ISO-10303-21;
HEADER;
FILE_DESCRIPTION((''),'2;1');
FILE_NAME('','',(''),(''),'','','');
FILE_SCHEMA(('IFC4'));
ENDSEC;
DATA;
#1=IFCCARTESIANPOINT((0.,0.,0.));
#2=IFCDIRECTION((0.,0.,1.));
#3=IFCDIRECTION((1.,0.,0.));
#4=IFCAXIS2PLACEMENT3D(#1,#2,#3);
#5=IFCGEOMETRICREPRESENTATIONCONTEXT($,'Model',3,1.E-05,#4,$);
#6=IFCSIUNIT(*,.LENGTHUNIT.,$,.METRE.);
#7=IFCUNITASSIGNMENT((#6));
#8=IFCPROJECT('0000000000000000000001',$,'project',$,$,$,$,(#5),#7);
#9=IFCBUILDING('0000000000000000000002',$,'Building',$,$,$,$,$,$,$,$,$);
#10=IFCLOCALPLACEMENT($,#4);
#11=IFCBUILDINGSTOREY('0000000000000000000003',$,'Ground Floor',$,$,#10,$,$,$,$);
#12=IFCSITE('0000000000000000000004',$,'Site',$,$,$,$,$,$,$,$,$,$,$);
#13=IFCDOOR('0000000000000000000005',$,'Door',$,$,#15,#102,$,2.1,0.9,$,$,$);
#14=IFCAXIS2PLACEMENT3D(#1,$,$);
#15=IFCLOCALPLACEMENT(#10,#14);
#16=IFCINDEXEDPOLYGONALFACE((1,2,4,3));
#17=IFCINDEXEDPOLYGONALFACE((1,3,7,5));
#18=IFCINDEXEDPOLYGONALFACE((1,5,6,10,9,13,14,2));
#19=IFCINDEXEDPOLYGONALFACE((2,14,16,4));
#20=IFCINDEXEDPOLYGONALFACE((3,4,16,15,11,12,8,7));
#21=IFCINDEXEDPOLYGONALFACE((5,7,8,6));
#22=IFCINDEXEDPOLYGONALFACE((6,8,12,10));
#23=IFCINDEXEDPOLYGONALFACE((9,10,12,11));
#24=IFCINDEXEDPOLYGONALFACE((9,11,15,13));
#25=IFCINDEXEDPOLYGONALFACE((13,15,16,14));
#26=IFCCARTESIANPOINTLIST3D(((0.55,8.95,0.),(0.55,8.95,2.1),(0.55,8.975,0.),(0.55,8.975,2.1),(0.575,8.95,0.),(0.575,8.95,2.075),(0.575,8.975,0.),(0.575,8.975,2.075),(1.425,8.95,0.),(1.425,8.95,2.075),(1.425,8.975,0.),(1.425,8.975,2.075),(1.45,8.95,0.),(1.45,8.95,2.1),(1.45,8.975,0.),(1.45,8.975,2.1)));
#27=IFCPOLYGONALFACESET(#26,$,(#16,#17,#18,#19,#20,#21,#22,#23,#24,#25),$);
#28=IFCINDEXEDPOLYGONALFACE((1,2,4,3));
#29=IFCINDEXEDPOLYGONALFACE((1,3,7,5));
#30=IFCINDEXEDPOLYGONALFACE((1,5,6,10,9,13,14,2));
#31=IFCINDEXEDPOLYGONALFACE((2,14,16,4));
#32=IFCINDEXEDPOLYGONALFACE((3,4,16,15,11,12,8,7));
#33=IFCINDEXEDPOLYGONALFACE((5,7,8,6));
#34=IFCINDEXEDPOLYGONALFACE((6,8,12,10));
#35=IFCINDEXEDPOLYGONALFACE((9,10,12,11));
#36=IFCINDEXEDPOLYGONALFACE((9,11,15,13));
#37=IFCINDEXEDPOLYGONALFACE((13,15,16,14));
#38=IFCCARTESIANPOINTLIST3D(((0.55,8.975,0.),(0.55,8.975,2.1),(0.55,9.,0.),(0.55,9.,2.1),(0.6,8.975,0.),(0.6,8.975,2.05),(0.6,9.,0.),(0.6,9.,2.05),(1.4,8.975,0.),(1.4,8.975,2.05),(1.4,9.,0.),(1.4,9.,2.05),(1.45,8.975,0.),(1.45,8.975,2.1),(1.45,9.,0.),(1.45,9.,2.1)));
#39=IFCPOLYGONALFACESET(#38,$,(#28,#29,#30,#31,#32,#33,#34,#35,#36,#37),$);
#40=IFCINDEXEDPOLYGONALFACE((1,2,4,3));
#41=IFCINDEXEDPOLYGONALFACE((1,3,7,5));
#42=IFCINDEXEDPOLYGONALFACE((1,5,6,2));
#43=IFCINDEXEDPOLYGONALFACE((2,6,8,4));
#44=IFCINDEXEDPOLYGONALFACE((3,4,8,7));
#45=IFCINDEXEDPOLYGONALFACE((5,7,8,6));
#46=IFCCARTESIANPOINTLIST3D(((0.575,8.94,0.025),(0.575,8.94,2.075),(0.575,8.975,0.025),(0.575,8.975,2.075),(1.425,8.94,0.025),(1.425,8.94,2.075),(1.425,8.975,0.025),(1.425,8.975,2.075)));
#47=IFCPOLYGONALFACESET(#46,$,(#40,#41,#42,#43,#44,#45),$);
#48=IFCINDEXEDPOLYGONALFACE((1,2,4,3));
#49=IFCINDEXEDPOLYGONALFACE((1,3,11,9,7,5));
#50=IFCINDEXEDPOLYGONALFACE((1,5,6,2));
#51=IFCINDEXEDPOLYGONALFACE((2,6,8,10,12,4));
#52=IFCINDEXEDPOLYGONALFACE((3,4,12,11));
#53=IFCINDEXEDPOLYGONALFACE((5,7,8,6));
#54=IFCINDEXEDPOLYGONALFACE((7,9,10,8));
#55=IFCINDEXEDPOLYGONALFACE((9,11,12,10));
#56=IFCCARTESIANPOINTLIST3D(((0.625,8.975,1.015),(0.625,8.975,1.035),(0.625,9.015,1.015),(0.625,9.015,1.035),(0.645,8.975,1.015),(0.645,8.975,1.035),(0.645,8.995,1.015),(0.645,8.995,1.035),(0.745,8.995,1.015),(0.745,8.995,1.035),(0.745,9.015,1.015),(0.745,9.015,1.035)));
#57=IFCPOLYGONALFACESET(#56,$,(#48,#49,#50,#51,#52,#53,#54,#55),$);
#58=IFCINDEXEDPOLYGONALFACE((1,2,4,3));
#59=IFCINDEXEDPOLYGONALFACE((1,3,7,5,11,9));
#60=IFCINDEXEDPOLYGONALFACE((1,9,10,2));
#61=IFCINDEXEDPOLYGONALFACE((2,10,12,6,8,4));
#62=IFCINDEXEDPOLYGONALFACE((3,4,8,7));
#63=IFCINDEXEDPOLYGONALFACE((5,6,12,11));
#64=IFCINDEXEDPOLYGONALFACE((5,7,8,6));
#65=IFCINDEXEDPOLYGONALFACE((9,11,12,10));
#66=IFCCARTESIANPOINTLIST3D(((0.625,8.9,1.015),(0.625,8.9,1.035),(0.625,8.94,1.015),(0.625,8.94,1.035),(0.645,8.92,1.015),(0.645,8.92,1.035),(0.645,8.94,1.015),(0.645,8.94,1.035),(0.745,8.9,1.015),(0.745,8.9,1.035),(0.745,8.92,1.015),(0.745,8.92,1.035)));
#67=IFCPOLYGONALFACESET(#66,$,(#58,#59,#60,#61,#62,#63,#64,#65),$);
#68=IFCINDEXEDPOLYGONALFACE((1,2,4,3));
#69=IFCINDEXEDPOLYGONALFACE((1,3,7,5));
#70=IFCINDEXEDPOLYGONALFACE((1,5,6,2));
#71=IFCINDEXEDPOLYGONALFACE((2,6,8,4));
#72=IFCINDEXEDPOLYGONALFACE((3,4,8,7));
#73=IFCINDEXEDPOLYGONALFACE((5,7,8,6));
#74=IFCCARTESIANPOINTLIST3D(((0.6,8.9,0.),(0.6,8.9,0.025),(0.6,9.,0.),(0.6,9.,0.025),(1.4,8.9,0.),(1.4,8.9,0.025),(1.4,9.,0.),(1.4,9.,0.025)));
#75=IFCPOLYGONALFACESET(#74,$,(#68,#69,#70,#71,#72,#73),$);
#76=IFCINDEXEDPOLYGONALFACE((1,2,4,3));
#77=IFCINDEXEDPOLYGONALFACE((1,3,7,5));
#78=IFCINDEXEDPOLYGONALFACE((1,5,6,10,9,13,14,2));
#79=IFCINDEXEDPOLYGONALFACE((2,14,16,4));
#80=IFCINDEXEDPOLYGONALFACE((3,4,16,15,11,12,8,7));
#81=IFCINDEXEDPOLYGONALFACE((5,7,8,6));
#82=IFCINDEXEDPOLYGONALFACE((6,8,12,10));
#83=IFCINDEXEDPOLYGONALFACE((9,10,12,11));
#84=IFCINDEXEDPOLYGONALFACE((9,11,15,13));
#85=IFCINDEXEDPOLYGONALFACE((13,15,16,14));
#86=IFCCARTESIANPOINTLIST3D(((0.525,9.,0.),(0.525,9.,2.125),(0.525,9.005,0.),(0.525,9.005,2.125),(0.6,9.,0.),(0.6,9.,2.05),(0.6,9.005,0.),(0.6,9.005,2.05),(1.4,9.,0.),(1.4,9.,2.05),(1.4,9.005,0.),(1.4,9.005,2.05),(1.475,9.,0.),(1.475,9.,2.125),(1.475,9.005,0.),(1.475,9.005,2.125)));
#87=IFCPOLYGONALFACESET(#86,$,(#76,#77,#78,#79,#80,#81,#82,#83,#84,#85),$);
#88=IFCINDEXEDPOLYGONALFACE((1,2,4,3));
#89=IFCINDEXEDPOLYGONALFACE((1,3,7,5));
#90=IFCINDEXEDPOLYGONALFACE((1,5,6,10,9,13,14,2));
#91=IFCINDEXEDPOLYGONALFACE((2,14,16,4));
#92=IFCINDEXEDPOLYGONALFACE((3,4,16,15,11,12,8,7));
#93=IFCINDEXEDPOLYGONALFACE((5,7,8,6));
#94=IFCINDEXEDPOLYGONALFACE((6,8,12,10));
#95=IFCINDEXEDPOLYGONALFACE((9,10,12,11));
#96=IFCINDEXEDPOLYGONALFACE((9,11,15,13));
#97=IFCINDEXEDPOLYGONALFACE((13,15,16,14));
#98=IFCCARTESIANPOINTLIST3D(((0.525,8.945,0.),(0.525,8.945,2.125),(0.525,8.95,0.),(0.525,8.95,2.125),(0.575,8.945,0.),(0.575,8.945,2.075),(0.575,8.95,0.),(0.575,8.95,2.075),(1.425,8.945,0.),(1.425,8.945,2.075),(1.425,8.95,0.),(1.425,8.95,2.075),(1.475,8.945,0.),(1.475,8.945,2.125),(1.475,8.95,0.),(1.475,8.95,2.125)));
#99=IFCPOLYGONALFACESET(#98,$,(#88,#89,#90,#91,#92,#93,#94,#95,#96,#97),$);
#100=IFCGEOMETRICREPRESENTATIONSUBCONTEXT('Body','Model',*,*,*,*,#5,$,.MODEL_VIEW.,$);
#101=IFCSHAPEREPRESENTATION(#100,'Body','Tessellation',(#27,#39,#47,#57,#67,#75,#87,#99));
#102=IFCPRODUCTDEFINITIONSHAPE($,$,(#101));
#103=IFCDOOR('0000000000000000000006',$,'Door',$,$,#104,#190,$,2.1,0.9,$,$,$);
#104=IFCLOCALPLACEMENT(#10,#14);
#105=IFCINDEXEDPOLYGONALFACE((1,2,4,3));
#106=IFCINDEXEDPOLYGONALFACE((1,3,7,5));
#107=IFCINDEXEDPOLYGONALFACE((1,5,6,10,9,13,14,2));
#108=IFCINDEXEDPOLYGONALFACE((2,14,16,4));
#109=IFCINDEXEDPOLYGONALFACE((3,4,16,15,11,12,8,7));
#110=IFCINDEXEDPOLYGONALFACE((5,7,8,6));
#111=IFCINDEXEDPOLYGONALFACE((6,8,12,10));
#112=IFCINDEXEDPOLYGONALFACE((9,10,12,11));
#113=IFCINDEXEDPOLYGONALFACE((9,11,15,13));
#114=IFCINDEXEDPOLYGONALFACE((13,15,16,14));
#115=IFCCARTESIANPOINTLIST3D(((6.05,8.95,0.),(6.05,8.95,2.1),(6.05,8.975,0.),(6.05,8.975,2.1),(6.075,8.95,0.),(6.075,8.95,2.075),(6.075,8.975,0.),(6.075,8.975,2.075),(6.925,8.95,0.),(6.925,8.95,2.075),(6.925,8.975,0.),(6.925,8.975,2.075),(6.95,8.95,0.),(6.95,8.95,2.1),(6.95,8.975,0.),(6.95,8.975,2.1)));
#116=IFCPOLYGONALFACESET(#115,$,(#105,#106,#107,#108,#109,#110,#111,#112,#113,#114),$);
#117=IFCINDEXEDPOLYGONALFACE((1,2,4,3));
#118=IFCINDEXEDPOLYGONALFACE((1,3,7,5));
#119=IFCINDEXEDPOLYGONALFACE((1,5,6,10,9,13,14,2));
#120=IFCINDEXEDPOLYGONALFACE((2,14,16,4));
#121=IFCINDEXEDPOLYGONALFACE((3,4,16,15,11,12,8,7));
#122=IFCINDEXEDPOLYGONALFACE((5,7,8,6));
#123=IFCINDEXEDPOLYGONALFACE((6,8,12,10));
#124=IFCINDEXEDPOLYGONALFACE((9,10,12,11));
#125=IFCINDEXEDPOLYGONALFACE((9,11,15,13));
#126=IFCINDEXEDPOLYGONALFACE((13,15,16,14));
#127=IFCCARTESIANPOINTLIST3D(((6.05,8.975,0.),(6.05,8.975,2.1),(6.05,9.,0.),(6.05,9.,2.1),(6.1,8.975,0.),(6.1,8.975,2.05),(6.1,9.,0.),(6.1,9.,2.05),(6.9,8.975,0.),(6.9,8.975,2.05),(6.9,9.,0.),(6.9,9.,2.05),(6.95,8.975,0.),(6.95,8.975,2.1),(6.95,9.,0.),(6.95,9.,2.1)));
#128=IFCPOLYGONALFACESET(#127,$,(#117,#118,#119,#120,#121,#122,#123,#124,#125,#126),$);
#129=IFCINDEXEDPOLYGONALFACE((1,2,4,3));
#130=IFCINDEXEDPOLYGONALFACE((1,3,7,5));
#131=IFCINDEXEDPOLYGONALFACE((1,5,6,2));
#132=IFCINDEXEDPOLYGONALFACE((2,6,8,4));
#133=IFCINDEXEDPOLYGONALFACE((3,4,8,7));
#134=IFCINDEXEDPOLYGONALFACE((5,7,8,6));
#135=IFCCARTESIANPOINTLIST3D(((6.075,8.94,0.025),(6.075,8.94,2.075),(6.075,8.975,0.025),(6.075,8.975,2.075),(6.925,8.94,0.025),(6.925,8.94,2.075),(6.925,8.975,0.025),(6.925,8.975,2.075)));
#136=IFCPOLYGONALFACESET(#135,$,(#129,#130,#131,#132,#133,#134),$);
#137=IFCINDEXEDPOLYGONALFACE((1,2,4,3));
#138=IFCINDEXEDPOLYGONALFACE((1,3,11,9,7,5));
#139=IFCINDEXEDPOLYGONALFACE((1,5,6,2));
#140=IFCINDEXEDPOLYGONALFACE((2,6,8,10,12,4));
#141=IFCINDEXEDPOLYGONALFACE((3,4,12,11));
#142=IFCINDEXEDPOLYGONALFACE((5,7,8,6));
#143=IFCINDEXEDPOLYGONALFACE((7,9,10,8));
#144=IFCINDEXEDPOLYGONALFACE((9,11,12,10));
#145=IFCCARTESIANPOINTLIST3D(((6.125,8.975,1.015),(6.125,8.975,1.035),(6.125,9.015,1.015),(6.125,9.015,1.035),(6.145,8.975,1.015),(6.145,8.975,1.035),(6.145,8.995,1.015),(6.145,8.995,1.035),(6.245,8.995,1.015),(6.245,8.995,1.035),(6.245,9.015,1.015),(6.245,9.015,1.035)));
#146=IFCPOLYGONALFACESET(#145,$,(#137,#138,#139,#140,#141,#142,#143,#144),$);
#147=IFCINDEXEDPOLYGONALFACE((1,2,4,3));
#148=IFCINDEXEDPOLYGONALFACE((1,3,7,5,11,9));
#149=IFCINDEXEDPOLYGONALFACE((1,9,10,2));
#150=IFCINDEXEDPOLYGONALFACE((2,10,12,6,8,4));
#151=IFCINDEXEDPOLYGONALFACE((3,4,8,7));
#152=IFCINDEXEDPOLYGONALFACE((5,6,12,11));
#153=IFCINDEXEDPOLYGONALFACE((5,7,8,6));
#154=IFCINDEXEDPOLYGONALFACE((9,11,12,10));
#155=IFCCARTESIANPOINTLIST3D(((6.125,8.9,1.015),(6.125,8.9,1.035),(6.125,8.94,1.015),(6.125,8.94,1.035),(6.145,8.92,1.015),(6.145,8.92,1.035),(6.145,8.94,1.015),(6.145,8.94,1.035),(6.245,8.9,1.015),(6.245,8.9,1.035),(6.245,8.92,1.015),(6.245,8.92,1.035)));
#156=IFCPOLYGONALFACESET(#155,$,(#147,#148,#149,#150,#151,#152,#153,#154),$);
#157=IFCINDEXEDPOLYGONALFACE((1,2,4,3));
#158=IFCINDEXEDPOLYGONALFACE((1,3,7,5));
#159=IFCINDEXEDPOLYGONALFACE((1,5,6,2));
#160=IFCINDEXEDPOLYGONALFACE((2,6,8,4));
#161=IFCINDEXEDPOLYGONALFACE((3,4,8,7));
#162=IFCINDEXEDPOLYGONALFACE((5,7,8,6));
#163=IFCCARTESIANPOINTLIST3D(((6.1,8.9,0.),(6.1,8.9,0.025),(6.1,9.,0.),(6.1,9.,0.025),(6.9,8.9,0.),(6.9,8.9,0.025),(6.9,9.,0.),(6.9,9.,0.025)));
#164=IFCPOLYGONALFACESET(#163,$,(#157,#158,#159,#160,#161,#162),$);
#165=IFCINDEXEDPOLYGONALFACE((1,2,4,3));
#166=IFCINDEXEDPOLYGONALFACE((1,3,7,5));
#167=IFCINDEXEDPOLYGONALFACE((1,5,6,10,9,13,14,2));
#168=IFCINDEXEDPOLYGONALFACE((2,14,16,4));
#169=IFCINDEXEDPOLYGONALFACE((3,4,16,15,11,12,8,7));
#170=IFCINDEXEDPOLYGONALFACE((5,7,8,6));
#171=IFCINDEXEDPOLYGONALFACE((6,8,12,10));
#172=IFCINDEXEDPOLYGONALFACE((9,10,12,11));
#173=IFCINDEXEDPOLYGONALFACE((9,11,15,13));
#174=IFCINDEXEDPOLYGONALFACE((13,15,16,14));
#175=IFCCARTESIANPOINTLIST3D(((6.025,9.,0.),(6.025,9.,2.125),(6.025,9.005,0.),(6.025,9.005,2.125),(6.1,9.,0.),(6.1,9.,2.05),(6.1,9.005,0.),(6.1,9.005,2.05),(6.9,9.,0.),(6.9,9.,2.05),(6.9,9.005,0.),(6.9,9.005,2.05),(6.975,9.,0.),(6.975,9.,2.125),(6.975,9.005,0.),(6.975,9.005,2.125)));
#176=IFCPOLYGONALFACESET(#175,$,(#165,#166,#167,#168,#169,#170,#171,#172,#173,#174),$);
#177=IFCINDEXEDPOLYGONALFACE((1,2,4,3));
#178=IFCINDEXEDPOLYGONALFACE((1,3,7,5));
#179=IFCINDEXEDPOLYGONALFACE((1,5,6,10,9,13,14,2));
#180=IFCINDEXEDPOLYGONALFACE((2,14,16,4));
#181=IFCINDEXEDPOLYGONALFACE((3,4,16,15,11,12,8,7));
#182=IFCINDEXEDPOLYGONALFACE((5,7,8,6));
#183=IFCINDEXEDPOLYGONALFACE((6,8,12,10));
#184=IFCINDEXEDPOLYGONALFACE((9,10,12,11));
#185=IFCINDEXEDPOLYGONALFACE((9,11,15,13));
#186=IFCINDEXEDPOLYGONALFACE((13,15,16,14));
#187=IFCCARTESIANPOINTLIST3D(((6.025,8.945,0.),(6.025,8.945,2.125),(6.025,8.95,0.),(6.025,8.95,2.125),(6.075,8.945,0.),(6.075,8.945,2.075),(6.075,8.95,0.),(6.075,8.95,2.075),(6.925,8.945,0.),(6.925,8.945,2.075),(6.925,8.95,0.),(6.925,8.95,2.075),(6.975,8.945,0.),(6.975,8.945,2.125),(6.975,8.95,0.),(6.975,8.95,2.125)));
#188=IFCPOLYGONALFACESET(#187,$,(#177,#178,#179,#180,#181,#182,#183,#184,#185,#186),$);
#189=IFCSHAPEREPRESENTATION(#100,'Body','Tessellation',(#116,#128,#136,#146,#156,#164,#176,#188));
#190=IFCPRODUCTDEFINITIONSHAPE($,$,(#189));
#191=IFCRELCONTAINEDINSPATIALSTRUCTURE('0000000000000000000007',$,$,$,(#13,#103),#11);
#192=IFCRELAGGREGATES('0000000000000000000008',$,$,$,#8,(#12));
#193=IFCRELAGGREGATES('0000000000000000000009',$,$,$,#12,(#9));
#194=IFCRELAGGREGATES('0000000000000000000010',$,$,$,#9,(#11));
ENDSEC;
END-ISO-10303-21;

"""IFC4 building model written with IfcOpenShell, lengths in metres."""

from ifc_helpers import new_model, si_unit, frame, origin_with_axes, place, context, subcontext, project, spatial, line, indexed_curve, outline, extrude, element, save


model = new_model("IFC4")

# Units and contexts
model_context = context("Model", 3, precision=1e-05, world=origin_with_axes())
body_context = subcontext(model_context, "Body", "Model", "MODEL_VIEW")
ifc_project = project(units=[si_unit("LENGTHUNIT", "METRE")], contexts=[model_context])

# Site, building, storey
site = spatial("IfcSite", under=ifc_project, Name="Site")
building = spatial("IfcBuilding", under=site, Name="Building")
storey_placement = place(None, origin_with_axes())
storey = spatial("IfcBuildingStorey", under=building, at=storey_placement, Name="Ground Floor")

# Doors
door_1_placement = place(storey_placement, frame((1.45, 9.0, 0.0), z_axis=(0.0, 0.0, 1.0), x_axis=(-1.0, 0.0, 0.0)))
element("IfcDoor", 1, at=door_1_placement, inside=storey, Name="Door", OverallHeight=2.1, OverallWidth=0.9, context=body_context, shape_type="SweptSolid", body=[
    extrude(outline(indexed_curve([(0.0, 0.0), (0.0, 2.1), (0.9, 2.1), (0.9, 0.0), (0.875, 0.0), (0.875, 2.075), (0.025, 2.075), (0.025, 0.0)], segments=[line(1, 2, 3, 4, 5, 6, 7, 8, 1)])), frame((0.0, 0.025, 0.0), z_axis=(0.0, -1.0, 0.0), x_axis=(1.0, 0.0, 0.0)), (0.0, 0.0, -1.0), 0.025),
    extrude(outline(indexed_curve([(0.0, 0.0), (0.0, 2.1), (0.9, 2.1), (0.9, 0.0), (0.85, 0.0), (0.85, 2.05), (0.05, 2.05), (0.05, 0.0)], segments=[line(1, 2, 3, 4, 5, 6, 7, 8, 1)])), frame((0.0, 0.0, 0.0), z_axis=(0.0, -1.0, 0.0), x_axis=(1.0, 0.0, 0.0)), (0.0, 0.0, -1.0), 0.025),
    extrude(outline(indexed_curve([(0.0, 0.0), (0.85, 0.0), (0.85, 0.035), (0.0, 0.035)], segments=[line(1, 2, 3, 4, 1)])), frame((0.025, 0.025, 0.025), z_axis=(0.0, 0.0, 1.0), x_axis=(1.0, 0.0, 0.0)), (0.0, 0.0, 1.0), 2.05),
    extrude(outline(indexed_curve([(0.0, 0.0), (0.0, -0.04), (-0.12, -0.04), (-0.12, -0.02), (-0.02, -0.02), (-0.02, 0.0)], segments=[line(1, 2, 3, 4, 5, 6, 1)])), frame((0.825, 0.025, 1.015), z_axis=(0.0, 0.0, 1.0), x_axis=(1.0, 0.0, 0.0)), (0.0, 0.0, 1.0), 0.02),
    extrude(outline(indexed_curve([(0.0, 0.0), (0.0, 0.04), (-0.12, 0.04), (-0.12, 0.02), (-0.02, 0.02), (-0.02, 0.0)], segments=[line(1, 2, 3, 4, 5, 6, 1)])), frame((0.825, 0.06, 1.015), z_axis=(0.0, 0.0, 1.0), x_axis=(1.0, 0.0, 0.0)), (0.0, 0.0, 1.0), 0.02),
    extrude(outline(indexed_curve([(0.0, 0.0), (0.8, 0.0), (0.8, 0.1), (0.0, 0.1)], segments=[line(1, 2, 3, 4, 1)])), frame((0.05, 0.0, 0.0), z_axis=(0.0, 0.0, 1.0), x_axis=(1.0, 0.0, 0.0)), (0.0, 0.0, 1.0), 0.025),
    extrude(outline(indexed_curve([(0.0, 0.0), (0.0, 2.125), (0.95, 2.125), (0.95, 0.0), (0.875, 0.0), (0.875, 2.05), (0.075, 2.05), (0.075, 0.0)], segments=[line(1, 2, 3, 4, 5, 6, 7, 8, 1)])), frame((-0.025, -0.005, 0.0), z_axis=(0.0, -1.0, 0.0), x_axis=(1.0, 0.0, 0.0)), (0.0, 0.0, -1.0), 0.005),
    extrude(outline(indexed_curve([(0.0, 0.0), (0.0, 2.125), (0.95, 2.125), (0.95, 0.0), (0.9, 0.0), (0.9, 2.075), (0.05, 2.075), (0.05, 0.0)], segments=[line(1, 2, 3, 4, 5, 6, 7, 8, 1)])), frame((-0.025, 0.05, 0.0), z_axis=(0.0, -1.0, 0.0), x_axis=(1.0, 0.0, 0.0)), (0.0, 0.0, -1.0), 0.005),
])
door_2_placement = place(storey_placement, frame((6.95, 9.0, 0.0), z_axis=(0.0, 0.0, 1.0), x_axis=(-1.0, 0.0, 0.0)))
element("IfcDoor", 2, at=door_2_placement, inside=storey, Name="Door", OverallHeight=2.1, OverallWidth=0.9, context=body_context, shape_type="SweptSolid", body=[
    extrude(outline(indexed_curve([(0.0, 0.0), (0.0, 2.1), (0.9, 2.1), (0.9, 0.0), (0.875, 0.0), (0.875, 2.075), (0.025, 2.075), (0.025, 0.0)], segments=[line(1, 2, 3, 4, 5, 6, 7, 8, 1)])), frame((0.0, 0.025, 0.0), z_axis=(0.0, -1.0, 0.0), x_axis=(1.0, 0.0, 0.0)), (0.0, 0.0, -1.0), 0.025),
    extrude(outline(indexed_curve([(0.0, 0.0), (0.0, 2.1), (0.9, 2.1), (0.9, 0.0), (0.85, 0.0), (0.85, 2.05), (0.05, 2.05), (0.05, 0.0)], segments=[line(1, 2, 3, 4, 5, 6, 7, 8, 1)])), frame((0.0, 0.0, 0.0), z_axis=(0.0, -1.0, 0.0), x_axis=(1.0, 0.0, 0.0)), (0.0, 0.0, -1.0), 0.025),
    extrude(outline(indexed_curve([(0.0, 0.0), (0.85, 0.0), (0.85, 0.035), (0.0, 0.035)], segments=[line(1, 2, 3, 4, 1)])), frame((0.025, 0.025, 0.025), z_axis=(0.0, 0.0, 1.0), x_axis=(1.0, 0.0, 0.0)), (0.0, 0.0, 1.0), 2.05),
    extrude(outline(indexed_curve([(0.0, 0.0), (0.0, -0.04), (-0.12, -0.04), (-0.12, -0.02), (-0.02, -0.02), (-0.02, 0.0)], segments=[line(1, 2, 3, 4, 5, 6, 1)])), frame((0.825, 0.025, 1.015), z_axis=(0.0, 0.0, 1.0), x_axis=(1.0, 0.0, 0.0)), (0.0, 0.0, 1.0), 0.02),
    extrude(outline(indexed_curve([(0.0, 0.0), (0.0, 0.04), (-0.12, 0.04), (-0.12, 0.02), (-0.02, 0.02), (-0.02, 0.0)], segments=[line(1, 2, 3, 4, 5, 6, 1)])), frame((0.825, 0.06, 1.015), z_axis=(0.0, 0.0, 1.0), x_axis=(1.0, 0.0, 0.0)), (0.0, 0.0, 1.0), 0.02),
    extrude(outline(indexed_curve([(0.0, 0.0), (0.8, 0.0), (0.8, 0.1), (0.0, 0.1)], segments=[line(1, 2, 3, 4, 1)])), frame((0.05, 0.0, 0.0), z_axis=(0.0, 0.0, 1.0), x_axis=(1.0, 0.0, 0.0)), (0.0, 0.0, 1.0), 0.025),
    extrude(outline(indexed_curve([(0.0, 0.0), (0.0, 2.125), (0.95, 2.125), (0.95, 0.0), (0.875, 0.0), (0.875, 2.05), (0.075, 2.05), (0.075, 0.0)], segments=[line(1, 2, 3, 4, 5, 6, 7, 8, 1)])), frame((-0.025, -0.005, 0.0), z_axis=(0.0, -1.0, 0.0), x_axis=(1.0, 0.0, 0.0)), (0.0, 0.0, -1.0), 0.005),
    extrude(outline(indexed_curve([(0.0, 0.0), (0.0, 2.125), (0.95, 2.125), (0.95, 0.0), (0.9, 0.0), (0.9, 2.075), (0.05, 2.075), (0.05, 0.0)], segments=[line(1, 2, 3, 4, 5, 6, 7, 8, 1)])), frame((-0.025, 0.05, 0.0), z_axis=(0.0, -1.0, 0.0), x_axis=(1.0, 0.0, 0.0)), (0.0, 0.0, -1.0), 0.005),
])

save(model, "model.ifc")
